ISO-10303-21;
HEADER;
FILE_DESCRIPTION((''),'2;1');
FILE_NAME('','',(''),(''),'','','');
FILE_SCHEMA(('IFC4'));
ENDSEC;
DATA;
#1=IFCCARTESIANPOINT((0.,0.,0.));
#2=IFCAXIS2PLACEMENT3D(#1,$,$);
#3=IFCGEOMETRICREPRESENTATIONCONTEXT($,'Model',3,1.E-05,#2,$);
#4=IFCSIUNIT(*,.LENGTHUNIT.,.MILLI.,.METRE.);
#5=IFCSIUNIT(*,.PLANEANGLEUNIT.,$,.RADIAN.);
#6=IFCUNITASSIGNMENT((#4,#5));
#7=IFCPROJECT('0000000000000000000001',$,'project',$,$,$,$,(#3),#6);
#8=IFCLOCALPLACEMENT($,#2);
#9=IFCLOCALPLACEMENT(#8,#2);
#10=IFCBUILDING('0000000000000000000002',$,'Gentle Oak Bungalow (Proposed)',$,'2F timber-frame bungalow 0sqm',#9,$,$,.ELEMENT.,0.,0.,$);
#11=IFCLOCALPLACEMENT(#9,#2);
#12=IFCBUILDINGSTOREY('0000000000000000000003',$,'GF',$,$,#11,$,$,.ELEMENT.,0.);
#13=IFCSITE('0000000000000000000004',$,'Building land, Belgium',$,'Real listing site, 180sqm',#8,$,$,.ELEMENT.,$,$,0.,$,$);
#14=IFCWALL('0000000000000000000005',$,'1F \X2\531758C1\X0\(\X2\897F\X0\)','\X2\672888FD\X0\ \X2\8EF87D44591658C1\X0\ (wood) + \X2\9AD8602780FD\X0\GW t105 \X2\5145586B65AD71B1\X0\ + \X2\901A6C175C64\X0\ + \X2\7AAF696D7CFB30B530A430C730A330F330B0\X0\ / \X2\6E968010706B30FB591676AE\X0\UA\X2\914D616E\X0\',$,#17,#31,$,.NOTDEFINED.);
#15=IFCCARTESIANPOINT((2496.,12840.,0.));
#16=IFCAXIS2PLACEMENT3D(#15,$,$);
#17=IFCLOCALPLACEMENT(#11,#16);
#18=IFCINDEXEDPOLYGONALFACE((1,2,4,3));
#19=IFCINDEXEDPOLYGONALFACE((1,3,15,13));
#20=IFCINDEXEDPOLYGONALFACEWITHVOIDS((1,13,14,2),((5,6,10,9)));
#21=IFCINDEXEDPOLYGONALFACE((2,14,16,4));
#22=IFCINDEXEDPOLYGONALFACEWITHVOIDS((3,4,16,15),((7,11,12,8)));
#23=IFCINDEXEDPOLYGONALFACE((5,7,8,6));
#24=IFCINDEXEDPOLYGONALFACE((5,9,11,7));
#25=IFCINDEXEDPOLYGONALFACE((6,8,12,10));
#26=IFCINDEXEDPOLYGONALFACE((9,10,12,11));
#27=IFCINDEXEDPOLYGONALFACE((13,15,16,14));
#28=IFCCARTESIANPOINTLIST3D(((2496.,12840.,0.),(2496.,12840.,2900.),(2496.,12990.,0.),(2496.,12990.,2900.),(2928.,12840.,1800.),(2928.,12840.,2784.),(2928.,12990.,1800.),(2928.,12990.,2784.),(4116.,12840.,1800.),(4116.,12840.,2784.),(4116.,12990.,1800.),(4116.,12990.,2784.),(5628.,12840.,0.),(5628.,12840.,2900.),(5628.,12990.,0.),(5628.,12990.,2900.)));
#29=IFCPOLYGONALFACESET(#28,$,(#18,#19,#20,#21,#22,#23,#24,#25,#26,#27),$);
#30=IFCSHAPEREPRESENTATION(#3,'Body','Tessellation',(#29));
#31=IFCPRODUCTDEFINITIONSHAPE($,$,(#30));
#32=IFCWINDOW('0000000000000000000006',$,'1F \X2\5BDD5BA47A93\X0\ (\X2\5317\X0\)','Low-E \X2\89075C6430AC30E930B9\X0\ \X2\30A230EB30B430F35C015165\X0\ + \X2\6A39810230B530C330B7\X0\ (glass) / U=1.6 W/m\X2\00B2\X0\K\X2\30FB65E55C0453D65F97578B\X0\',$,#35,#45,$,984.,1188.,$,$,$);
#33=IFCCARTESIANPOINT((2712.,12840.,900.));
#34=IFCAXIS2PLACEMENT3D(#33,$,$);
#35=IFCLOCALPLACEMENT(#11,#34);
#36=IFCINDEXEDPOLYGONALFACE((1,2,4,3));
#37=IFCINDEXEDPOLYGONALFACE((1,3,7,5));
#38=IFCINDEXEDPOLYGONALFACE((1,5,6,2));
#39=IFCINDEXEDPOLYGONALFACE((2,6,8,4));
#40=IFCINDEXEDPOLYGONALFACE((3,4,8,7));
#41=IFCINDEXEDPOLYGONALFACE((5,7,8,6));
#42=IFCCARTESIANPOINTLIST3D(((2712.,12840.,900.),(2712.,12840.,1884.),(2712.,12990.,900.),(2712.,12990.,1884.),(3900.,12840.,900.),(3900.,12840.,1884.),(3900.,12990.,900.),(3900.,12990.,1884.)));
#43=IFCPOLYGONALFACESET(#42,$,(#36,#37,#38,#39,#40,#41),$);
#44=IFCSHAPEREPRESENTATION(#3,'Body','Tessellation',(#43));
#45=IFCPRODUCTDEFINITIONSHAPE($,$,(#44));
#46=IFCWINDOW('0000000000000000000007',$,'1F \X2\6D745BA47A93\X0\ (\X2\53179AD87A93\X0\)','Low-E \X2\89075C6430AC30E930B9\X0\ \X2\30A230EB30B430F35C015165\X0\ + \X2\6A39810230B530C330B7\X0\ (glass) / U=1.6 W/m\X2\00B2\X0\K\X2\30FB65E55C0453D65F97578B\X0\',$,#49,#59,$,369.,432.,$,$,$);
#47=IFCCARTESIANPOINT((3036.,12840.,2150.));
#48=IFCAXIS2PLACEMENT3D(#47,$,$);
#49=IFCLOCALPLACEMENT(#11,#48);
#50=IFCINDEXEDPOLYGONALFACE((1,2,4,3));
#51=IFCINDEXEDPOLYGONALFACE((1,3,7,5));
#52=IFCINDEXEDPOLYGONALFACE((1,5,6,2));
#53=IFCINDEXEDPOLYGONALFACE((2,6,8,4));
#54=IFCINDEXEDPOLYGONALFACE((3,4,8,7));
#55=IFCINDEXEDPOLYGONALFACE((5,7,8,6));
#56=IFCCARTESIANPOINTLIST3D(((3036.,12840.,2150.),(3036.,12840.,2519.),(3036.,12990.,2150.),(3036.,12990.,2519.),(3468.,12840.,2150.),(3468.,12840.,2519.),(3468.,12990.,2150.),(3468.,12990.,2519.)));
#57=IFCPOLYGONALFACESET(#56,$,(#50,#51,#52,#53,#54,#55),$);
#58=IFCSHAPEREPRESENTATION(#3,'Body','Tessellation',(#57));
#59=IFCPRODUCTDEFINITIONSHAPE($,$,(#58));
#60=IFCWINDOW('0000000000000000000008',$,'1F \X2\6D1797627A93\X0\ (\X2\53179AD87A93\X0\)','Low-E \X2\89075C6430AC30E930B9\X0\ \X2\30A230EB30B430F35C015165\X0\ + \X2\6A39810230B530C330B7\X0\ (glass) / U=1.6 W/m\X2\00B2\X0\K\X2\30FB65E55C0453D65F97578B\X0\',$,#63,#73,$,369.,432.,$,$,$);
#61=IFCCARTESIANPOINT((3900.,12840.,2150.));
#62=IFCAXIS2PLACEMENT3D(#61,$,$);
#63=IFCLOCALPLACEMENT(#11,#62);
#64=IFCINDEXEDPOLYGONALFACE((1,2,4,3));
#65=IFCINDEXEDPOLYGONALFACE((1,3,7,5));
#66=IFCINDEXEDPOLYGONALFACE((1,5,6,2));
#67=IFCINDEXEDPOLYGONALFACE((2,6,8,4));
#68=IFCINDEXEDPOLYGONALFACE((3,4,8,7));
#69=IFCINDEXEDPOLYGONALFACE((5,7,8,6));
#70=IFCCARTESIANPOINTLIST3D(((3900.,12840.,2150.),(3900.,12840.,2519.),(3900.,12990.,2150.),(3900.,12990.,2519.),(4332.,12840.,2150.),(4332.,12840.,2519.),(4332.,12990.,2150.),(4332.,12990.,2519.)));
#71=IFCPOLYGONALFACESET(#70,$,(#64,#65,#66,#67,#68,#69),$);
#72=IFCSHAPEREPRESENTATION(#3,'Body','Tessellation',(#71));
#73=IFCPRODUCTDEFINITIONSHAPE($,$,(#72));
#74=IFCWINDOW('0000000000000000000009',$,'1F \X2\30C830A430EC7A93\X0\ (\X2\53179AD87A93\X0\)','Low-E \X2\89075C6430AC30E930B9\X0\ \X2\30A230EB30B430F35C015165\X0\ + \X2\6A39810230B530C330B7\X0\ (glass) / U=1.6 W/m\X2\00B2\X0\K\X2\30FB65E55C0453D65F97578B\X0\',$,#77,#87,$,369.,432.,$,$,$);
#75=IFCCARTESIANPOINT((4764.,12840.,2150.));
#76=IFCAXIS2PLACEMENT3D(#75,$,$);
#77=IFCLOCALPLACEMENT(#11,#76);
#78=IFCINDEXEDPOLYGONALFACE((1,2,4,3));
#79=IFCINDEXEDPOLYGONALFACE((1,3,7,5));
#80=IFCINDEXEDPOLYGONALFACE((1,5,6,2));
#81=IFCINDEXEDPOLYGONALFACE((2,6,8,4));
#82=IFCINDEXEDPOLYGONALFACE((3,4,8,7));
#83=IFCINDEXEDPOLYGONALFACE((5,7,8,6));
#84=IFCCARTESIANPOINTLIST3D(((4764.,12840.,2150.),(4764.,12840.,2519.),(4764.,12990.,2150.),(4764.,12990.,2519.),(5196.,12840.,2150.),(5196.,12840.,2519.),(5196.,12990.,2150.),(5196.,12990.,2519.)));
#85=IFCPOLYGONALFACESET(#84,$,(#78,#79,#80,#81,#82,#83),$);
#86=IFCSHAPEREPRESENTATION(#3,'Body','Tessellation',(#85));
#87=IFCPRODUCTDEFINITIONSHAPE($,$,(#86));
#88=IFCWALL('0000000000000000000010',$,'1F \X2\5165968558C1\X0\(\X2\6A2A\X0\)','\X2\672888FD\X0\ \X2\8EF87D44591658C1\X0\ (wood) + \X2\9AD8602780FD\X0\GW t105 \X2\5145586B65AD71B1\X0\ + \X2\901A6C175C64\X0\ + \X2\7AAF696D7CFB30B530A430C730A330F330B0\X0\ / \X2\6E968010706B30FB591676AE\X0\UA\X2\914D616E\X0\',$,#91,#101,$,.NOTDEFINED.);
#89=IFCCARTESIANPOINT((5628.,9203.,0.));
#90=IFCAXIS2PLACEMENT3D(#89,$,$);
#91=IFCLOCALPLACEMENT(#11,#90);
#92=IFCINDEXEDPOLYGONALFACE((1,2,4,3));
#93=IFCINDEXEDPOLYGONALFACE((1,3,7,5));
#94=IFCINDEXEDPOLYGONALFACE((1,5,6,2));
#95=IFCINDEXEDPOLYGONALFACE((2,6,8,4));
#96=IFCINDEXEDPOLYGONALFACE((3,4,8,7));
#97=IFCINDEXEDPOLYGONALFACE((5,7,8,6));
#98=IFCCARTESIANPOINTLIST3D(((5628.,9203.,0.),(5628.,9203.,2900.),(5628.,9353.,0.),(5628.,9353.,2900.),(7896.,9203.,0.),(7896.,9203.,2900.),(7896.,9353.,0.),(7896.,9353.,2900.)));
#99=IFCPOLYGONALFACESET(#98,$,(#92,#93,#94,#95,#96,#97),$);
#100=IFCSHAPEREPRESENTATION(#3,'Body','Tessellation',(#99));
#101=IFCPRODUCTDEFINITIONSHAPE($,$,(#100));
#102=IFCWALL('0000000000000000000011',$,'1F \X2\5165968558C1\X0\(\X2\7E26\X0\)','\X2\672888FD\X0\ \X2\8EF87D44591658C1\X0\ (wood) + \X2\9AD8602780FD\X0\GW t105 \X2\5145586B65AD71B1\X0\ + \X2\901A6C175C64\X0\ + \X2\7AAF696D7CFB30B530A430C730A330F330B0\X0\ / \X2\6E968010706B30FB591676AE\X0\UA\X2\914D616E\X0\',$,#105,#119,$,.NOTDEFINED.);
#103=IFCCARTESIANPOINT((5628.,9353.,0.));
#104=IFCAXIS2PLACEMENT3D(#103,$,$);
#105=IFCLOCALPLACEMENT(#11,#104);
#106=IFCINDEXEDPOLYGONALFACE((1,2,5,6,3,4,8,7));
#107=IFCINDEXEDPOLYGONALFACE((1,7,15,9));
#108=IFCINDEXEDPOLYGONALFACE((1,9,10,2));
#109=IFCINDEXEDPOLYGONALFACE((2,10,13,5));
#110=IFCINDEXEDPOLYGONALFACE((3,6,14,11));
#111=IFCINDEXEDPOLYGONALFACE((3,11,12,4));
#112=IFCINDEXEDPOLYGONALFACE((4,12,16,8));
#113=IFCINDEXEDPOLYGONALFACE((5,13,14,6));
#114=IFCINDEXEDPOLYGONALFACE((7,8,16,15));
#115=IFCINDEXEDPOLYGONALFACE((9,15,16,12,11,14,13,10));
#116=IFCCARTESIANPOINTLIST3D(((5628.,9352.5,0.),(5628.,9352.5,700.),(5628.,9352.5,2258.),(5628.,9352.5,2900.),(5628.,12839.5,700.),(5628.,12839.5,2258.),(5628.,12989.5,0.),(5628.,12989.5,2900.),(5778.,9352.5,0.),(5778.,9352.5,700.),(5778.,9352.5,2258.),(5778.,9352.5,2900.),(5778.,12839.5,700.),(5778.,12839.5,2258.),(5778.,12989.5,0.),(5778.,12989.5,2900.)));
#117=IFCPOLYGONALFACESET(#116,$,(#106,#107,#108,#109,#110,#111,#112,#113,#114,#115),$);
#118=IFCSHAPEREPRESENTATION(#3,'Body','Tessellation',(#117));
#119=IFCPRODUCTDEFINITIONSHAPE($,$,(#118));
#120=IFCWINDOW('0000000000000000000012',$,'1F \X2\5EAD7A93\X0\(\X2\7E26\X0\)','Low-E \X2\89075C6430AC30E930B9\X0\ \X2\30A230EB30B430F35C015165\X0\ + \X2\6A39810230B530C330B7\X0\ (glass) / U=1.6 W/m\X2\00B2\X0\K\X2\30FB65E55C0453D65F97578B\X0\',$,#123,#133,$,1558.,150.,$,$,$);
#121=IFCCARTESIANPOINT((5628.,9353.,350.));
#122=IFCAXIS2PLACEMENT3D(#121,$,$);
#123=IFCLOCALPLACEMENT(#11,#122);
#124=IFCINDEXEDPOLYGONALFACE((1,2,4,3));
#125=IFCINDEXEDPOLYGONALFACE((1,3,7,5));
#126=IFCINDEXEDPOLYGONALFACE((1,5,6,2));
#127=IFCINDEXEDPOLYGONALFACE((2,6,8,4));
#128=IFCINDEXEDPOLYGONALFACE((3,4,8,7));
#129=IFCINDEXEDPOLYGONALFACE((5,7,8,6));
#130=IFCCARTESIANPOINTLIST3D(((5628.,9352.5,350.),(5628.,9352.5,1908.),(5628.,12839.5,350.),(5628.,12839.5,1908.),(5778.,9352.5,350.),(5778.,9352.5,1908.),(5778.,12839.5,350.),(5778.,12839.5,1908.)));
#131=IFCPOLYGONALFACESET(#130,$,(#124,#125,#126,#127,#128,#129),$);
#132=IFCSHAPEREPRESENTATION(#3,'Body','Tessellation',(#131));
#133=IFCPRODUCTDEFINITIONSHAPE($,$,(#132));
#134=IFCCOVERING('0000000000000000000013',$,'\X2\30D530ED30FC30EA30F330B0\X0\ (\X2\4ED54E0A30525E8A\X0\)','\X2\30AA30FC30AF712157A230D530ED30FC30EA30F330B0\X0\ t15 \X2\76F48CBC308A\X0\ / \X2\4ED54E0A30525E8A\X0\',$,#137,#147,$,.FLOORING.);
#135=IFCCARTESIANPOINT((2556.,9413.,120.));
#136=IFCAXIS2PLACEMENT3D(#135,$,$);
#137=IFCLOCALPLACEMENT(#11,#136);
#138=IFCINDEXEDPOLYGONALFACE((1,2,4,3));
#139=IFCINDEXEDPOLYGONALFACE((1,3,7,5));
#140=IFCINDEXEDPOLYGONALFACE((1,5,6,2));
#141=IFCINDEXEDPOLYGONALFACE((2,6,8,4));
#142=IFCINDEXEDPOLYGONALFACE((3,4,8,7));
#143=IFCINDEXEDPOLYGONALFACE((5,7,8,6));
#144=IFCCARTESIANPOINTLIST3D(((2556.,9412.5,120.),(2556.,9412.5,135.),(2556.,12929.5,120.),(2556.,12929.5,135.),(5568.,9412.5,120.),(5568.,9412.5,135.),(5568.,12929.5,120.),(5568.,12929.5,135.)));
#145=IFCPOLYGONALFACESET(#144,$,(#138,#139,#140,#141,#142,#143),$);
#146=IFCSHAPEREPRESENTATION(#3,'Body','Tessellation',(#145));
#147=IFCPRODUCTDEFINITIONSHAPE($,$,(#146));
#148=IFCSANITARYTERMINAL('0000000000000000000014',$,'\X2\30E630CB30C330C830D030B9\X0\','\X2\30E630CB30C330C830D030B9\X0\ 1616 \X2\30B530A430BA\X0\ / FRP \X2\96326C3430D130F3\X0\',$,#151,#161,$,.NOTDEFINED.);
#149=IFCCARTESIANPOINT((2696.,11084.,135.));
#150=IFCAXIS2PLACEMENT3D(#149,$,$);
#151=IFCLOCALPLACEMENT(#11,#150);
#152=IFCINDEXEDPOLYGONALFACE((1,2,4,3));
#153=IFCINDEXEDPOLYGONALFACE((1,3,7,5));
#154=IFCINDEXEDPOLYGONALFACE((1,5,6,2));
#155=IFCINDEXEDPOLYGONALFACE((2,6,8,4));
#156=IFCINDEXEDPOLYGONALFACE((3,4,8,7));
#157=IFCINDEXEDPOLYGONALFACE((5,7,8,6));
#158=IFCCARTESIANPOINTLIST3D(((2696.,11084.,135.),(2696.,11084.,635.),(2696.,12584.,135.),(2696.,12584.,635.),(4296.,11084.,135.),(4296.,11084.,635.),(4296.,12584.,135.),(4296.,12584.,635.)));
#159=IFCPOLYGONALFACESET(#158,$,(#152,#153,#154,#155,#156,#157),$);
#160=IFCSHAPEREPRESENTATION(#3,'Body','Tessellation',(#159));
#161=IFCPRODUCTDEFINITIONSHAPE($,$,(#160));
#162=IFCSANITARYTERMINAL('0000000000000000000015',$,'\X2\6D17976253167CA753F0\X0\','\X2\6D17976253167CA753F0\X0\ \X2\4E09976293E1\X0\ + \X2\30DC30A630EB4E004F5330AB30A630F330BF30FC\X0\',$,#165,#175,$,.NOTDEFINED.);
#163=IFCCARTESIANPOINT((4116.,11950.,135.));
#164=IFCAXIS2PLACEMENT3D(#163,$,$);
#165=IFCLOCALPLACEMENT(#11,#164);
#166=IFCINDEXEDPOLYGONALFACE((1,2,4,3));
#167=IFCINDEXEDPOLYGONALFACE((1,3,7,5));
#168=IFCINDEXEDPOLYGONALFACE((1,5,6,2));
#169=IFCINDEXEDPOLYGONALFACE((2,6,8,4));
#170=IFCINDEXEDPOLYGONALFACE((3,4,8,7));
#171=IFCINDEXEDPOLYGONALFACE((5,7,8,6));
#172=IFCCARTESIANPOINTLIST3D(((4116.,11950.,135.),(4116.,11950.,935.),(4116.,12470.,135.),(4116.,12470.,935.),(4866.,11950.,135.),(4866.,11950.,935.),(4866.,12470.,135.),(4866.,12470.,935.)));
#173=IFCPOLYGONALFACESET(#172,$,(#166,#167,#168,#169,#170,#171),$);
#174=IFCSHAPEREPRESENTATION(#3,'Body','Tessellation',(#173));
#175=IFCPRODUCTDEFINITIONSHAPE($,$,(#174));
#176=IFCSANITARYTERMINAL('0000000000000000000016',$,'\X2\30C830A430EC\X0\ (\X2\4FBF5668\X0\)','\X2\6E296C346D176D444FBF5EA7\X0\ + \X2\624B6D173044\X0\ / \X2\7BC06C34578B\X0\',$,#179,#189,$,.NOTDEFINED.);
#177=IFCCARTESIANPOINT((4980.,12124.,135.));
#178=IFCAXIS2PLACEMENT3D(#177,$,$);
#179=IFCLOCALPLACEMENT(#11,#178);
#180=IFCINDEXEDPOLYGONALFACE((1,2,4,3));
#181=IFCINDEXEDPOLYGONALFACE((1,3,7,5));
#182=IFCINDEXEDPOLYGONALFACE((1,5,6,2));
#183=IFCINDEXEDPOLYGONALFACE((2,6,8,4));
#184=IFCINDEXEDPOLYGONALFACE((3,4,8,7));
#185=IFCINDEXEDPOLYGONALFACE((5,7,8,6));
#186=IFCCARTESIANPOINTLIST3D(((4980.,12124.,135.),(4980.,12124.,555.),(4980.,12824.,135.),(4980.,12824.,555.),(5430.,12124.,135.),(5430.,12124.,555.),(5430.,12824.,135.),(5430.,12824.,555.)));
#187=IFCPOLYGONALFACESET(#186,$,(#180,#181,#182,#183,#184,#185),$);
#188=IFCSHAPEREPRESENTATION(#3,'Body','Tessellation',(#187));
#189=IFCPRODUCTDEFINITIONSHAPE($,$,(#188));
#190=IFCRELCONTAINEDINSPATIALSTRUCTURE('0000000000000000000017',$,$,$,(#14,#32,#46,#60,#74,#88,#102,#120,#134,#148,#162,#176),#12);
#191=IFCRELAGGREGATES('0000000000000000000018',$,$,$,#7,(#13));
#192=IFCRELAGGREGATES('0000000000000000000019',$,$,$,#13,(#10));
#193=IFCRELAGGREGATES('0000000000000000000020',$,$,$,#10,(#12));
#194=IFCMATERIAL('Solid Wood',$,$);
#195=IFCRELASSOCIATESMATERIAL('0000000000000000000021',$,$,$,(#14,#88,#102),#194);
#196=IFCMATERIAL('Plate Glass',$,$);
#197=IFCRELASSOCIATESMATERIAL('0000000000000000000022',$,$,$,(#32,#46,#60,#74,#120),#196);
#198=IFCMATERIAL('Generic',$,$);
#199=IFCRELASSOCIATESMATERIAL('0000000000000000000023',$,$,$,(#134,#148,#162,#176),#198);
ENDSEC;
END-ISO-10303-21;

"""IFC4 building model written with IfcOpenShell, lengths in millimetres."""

from ifc_helpers import new_model, si_unit, frame, frame_2d, origin, place, context, project, spatial, rectangle, extrude, material, element, fill, save


model = new_model("IFC4")

# Units and contexts
model_context = context("Model", 3, precision=1e-05, world=origin())
ifc_project = project(units=[si_unit("LENGTHUNIT", "METRE", prefix="MILLI"), si_unit("PLANEANGLEUNIT", "RADIAN")], contexts=[model_context])

# Site, building, storey
site_placement = place(None, origin())
site = spatial("IfcSite", under=ifc_project, at=site_placement, Name="Building land, Belgium", ObjectType="Real listing site, 180sqm", CompositionType="ELEMENT", RefElevation=0.0)
building_placement = place(site_placement, origin())
building = spatial("IfcBuilding", under=site, at=building_placement, Name="Gentle Oak Bungalow (Proposed)", ObjectType="2F timber-frame bungalow 0sqm", CompositionType="ELEMENT", ElevationOfRefHeight=0.0, ElevationOfTerrain=0.0)
storey_placement = place(building_placement, origin())
storey = spatial("IfcBuildingStorey", under=building, at=storey_placement, Name="GF", CompositionType="ELEMENT", Elevation=0.0)

# Shared definitions
ifc_material_1 = material(Name="Solid Wood")

# Wall, openings, windows
wall_1_placement = place(storey_placement, frame((2496.0, 12840.0, 0.0)))
wall_1 = element("IfcWall", 1, at=wall_1_placement, inside=storey, material=ifc_material_1, Name="1F 北壁(西)", Description="木製 軸組外壁 (wood) + 高性能GW t105 充填断熱 + 通気層 + 窯業系サイディング / 準耐火・外皮UA配慮", PredefinedType="NOTDEFINED", context=model_context, shape_type="SweptSolid", body=[
    extrude(rectangle(XDim=3132.0, YDim=150.0, at=frame_2d((1566.0, 75.0))), frame((2496.0, 12840.0, 0.0)), (0.0, 0.0, 1.0), 2900.0),
])
opening_1_placement = place(storey_placement, frame((2712.0, 12840.0, 900.0)))
opening_1 = element("IfcOpeningElement", 2, at=opening_1_placement, cuts=wall_1, PredefinedType="NOTDEFINED", context=model_context, shape_type="SweptSolid", body=[
    extrude(rectangle(XDim=1188.0, YDim=150.0, at=frame_2d((594.0, 75.0))), frame((2712.0, 12840.0, 900.0)), (0.0, 0.0, 1.0), 984.0),
])
opening_2_placement = place(storey_placement, frame((3036.0, 12840.0, 2150.0)))
opening_2 = element("IfcOpeningElement", 3, at=opening_2_placement, cuts=wall_1, PredefinedType="NOTDEFINED", context=model_context, shape_type="SweptSolid", body=[
    extrude(rectangle(XDim=432.0, YDim=150.0, at=frame_2d((216.0, 75.0))), frame((3036.0, 12840.0, 2150.0)), (0.0, 0.0, 1.0), 369.0),
])
opening_3_placement = place(storey_placement, frame((3900.0, 12840.0, 2150.0)))
opening_3 = element("IfcOpeningElement", 4, at=opening_3_placement, cuts=wall_1, PredefinedType="NOTDEFINED", context=model_context, shape_type="SweptSolid", body=[
    extrude(rectangle(XDim=432.0, YDim=150.0, at=frame_2d((216.0, 75.0))), frame((3900.0, 12840.0, 2150.0)), (0.0, 0.0, 1.0), 369.0),
])
opening_4_placement = place(storey_placement, frame((4764.0, 12840.0, 2150.0)))
opening_4 = element("IfcOpeningElement", 5, at=opening_4_placement, cuts=wall_1, PredefinedType="NOTDEFINED", context=model_context, shape_type="SweptSolid", body=[
    extrude(rectangle(XDim=432.0, YDim=150.0, at=frame_2d((216.0, 75.0))), frame((4764.0, 12840.0, 2150.0)), (0.0, 0.0, 1.0), 369.0),
])
ifc_material_2 = material(Name="Plate Glass")
window_1_placement = place(storey_placement, frame((2712.0, 12840.0, 900.0)))
window_1 = element("IfcWindow", 6, at=window_1_placement, inside=storey, material=ifc_material_2, Name="1F 寝室窓 (北)", Description="Low-E 複層ガラス アルゴン封入 + 樹脂サッシ (glass) / U=1.6 W/m²K・日射取得型", OverallHeight=984.0, OverallWidth=1188.0, context=model_context, shape_type="SweptSolid", body=[
    extrude(rectangle(XDim=1188.0, YDim=150.0, at=frame_2d((594.0, 75.0))), frame((2712.0, 12840.0, 900.0)), (0.0, 0.0, 1.0), 984.0),
])
fill(opening_1, window_1)
window_2_placement = place(storey_placement, frame((3036.0, 12840.0, 2150.0)))
window_2 = element("IfcWindow", 7, at=window_2_placement, inside=storey, material=ifc_material_2, Name="1F 浴室窓 (北高窓)", Description="Low-E 複層ガラス アルゴン封入 + 樹脂サッシ (glass) / U=1.6 W/m²K・日射取得型", OverallHeight=369.0, OverallWidth=432.0, context=model_context, shape_type="SweptSolid", body=[
    extrude(rectangle(XDim=432.0, YDim=150.0, at=frame_2d((216.0, 75.0))), frame((3036.0, 12840.0, 2150.0)), (0.0, 0.0, 1.0), 369.0),
])
fill(opening_2, window_2)
window_3_placement = place(storey_placement, frame((3900.0, 12840.0, 2150.0)))
window_3 = element("IfcWindow", 8, at=window_3_placement, inside=storey, material=ifc_material_2, Name="1F 洗面窓 (北高窓)", Description="Low-E 複層ガラス アルゴン封入 + 樹脂サッシ (glass) / U=1.6 W/m²K・日射取得型", OverallHeight=369.0, OverallWidth=432.0, context=model_context, shape_type="SweptSolid", body=[
    extrude(rectangle(XDim=432.0, YDim=150.0, at=frame_2d((216.0, 75.0))), frame((3900.0, 12840.0, 2150.0)), (0.0, 0.0, 1.0), 369.0),
])
fill(opening_3, window_3)
window_4_placement = place(storey_placement, frame((4764.0, 12840.0, 2150.0)))
window_4 = element("IfcWindow", 9, at=window_4_placement, inside=storey, material=ifc_material_2, Name="1F トイレ窓 (北高窓)", Description="Low-E 複層ガラス アルゴン封入 + 樹脂サッシ (glass) / U=1.6 W/m²K・日射取得型", OverallHeight=369.0, OverallWidth=432.0, context=model_context, shape_type="SweptSolid", body=[
    extrude(rectangle(XDim=432.0, YDim=150.0, at=frame_2d((216.0, 75.0))), frame((4764.0, 12840.0, 2150.0)), (0.0, 0.0, 1.0), 369.0),
])
fill(opening_4, window_4)

# Wall
wall_2_placement = place(storey_placement, frame((5628.0, 9203.0, 0.0)))
element("IfcWall", 10, at=wall_2_placement, inside=storey, material=ifc_material_1, Name="1F 入隅壁(横)", Description="木製 軸組外壁 (wood) + 高性能GW t105 充填断熱 + 通気層 + 窯業系サイディング / 準耐火・外皮UA配慮", PredefinedType="NOTDEFINED", context=model_context, shape_type="SweptSolid", body=[
    extrude(rectangle(XDim=2268.0, YDim=150.0, at=frame_2d((1134.0, 75.0))), frame((5628.0, 9203.0, 0.0)), (0.0, 0.0, 1.0), 2900.0),
])

# Wall, opening, window
wall_3_placement = place(storey_placement, frame((5628.0, 9353.0, 0.0)))
wall_3 = element("IfcWall", 11, at=wall_3_placement, inside=storey, material=ifc_material_1, Name="1F 入隅壁(縦)", Description="木製 軸組外壁 (wood) + 高性能GW t105 充填断熱 + 通気層 + 窯業系サイディング / 準耐火・外皮UA配慮", PredefinedType="NOTDEFINED", context=model_context, shape_type="SweptSolid", body=[
    extrude(rectangle(XDim=150.0, YDim=3637.0, at=frame_2d((75.0, 1818.0))), frame((5628.0, 9353.0, 0.0)), (0.0, 0.0, 1.0), 2900.0),
])
opening_5_placement = place(storey_placement, frame((5628.0, 9353.0, 350.0)))
opening_5 = element("IfcOpeningElement", 12, at=opening_5_placement, cuts=wall_3, PredefinedType="NOTDEFINED", context=model_context, shape_type="SweptSolid", body=[
    extrude(rectangle(XDim=150.0, YDim=3487.0, at=frame_2d((75.0, 1743.0))), frame((5628.0, 9353.0, 350.0)), (0.0, 0.0, 1.0), 1558.0),
])
window_5_placement = place(storey_placement, frame((5628.0, 9353.0, 350.0)))
window_5 = element("IfcWindow", 13, at=window_5_placement, inside=storey, material=ifc_material_2, Name="1F 庭窓(縦)", Description="Low-E 複層ガラス アルゴン封入 + 樹脂サッシ (glass) / U=1.6 W/m²K・日射取得型", OverallHeight=1558.0, OverallWidth=150.0, context=model_context, shape_type="SweptSolid", body=[
    extrude(rectangle(XDim=150.0, YDim=3487.0, at=frame_2d((75.0, 1743.0))), frame((5628.0, 9353.0, 350.0)), (0.0, 0.0, 1.0), 1558.0),
])
fill(opening_5, window_5)

# Covering
ifc_material_3 = material(Name="Generic")
covering_placement = place(storey_placement, frame((2556.0, 9413.0, 120.0)))
element("IfcCovering", 14, at=covering_placement, inside=storey, material=ifc_material_3, Name="フローリング (仕上げ床)", Description="オーク無垢フローリング t15 直貼り / 仕上げ床", PredefinedType="FLOORING", context=model_context, shape_type="SweptSolid", body=[
    extrude(rectangle(XDim=3012.0, YDim=3517.0, at=frame_2d((1506.0, 1758.0))), frame((2556.0, 9413.0, 120.0)), (0.0, 0.0, 1.0), 15.0),
])

# Sanitary terminals
sanitary_terminal_1_placement = place(storey_placement, frame((2696.0, 11084.0, 135.0)))
element("IfcSanitaryTerminal", 15, at=sanitary_terminal_1_placement, inside=storey, material=ifc_material_3, Name="ユニットバス", Description="ユニットバス 1616 サイズ / FRP 防水パン", PredefinedType="NOTDEFINED", context=model_context, shape_type="SweptSolid", body=[
    extrude(rectangle(XDim=1600.0, YDim=1500.0, at=frame_2d((800.0, 750.0))), frame((2696.0, 11084.0, 135.0)), (0.0, 0.0, 1.0), 500.0),
])
sanitary_terminal_2_placement = place(storey_placement, frame((4116.0, 11950.0, 135.0)))
element("IfcSanitaryTerminal", 16, at=sanitary_terminal_2_placement, inside=storey, material=ifc_material_3, Name="洗面化粧台", Description="洗面化粧台 三面鏡 + ボウル一体カウンター", PredefinedType="NOTDEFINED", context=model_context, shape_type="SweptSolid", body=[
    extrude(rectangle(XDim=750.0, YDim=520.0, at=frame_2d((375.0, 260.0))), frame((4116.0, 11950.0, 135.0)), (0.0, 0.0, 1.0), 800.0),
])
sanitary_terminal_3_placement = place(storey_placement, frame((4980.0, 12124.0, 135.0)))
element("IfcSanitaryTerminal", 17, at=sanitary_terminal_3_placement, inside=storey, material=ifc_material_3, Name="トイレ (便器)", Description="温水洗浄便座 + 手洗い / 節水型", PredefinedType="NOTDEFINED", context=model_context, shape_type="SweptSolid", body=[
    extrude(rectangle(XDim=450.0, YDim=700.0, at=frame_2d((225.0, 350.0))), frame((4980.0, 12124.0, 135.0)), (0.0, 0.0, 1.0), 420.0),
])

save(model, "model.ifc")
